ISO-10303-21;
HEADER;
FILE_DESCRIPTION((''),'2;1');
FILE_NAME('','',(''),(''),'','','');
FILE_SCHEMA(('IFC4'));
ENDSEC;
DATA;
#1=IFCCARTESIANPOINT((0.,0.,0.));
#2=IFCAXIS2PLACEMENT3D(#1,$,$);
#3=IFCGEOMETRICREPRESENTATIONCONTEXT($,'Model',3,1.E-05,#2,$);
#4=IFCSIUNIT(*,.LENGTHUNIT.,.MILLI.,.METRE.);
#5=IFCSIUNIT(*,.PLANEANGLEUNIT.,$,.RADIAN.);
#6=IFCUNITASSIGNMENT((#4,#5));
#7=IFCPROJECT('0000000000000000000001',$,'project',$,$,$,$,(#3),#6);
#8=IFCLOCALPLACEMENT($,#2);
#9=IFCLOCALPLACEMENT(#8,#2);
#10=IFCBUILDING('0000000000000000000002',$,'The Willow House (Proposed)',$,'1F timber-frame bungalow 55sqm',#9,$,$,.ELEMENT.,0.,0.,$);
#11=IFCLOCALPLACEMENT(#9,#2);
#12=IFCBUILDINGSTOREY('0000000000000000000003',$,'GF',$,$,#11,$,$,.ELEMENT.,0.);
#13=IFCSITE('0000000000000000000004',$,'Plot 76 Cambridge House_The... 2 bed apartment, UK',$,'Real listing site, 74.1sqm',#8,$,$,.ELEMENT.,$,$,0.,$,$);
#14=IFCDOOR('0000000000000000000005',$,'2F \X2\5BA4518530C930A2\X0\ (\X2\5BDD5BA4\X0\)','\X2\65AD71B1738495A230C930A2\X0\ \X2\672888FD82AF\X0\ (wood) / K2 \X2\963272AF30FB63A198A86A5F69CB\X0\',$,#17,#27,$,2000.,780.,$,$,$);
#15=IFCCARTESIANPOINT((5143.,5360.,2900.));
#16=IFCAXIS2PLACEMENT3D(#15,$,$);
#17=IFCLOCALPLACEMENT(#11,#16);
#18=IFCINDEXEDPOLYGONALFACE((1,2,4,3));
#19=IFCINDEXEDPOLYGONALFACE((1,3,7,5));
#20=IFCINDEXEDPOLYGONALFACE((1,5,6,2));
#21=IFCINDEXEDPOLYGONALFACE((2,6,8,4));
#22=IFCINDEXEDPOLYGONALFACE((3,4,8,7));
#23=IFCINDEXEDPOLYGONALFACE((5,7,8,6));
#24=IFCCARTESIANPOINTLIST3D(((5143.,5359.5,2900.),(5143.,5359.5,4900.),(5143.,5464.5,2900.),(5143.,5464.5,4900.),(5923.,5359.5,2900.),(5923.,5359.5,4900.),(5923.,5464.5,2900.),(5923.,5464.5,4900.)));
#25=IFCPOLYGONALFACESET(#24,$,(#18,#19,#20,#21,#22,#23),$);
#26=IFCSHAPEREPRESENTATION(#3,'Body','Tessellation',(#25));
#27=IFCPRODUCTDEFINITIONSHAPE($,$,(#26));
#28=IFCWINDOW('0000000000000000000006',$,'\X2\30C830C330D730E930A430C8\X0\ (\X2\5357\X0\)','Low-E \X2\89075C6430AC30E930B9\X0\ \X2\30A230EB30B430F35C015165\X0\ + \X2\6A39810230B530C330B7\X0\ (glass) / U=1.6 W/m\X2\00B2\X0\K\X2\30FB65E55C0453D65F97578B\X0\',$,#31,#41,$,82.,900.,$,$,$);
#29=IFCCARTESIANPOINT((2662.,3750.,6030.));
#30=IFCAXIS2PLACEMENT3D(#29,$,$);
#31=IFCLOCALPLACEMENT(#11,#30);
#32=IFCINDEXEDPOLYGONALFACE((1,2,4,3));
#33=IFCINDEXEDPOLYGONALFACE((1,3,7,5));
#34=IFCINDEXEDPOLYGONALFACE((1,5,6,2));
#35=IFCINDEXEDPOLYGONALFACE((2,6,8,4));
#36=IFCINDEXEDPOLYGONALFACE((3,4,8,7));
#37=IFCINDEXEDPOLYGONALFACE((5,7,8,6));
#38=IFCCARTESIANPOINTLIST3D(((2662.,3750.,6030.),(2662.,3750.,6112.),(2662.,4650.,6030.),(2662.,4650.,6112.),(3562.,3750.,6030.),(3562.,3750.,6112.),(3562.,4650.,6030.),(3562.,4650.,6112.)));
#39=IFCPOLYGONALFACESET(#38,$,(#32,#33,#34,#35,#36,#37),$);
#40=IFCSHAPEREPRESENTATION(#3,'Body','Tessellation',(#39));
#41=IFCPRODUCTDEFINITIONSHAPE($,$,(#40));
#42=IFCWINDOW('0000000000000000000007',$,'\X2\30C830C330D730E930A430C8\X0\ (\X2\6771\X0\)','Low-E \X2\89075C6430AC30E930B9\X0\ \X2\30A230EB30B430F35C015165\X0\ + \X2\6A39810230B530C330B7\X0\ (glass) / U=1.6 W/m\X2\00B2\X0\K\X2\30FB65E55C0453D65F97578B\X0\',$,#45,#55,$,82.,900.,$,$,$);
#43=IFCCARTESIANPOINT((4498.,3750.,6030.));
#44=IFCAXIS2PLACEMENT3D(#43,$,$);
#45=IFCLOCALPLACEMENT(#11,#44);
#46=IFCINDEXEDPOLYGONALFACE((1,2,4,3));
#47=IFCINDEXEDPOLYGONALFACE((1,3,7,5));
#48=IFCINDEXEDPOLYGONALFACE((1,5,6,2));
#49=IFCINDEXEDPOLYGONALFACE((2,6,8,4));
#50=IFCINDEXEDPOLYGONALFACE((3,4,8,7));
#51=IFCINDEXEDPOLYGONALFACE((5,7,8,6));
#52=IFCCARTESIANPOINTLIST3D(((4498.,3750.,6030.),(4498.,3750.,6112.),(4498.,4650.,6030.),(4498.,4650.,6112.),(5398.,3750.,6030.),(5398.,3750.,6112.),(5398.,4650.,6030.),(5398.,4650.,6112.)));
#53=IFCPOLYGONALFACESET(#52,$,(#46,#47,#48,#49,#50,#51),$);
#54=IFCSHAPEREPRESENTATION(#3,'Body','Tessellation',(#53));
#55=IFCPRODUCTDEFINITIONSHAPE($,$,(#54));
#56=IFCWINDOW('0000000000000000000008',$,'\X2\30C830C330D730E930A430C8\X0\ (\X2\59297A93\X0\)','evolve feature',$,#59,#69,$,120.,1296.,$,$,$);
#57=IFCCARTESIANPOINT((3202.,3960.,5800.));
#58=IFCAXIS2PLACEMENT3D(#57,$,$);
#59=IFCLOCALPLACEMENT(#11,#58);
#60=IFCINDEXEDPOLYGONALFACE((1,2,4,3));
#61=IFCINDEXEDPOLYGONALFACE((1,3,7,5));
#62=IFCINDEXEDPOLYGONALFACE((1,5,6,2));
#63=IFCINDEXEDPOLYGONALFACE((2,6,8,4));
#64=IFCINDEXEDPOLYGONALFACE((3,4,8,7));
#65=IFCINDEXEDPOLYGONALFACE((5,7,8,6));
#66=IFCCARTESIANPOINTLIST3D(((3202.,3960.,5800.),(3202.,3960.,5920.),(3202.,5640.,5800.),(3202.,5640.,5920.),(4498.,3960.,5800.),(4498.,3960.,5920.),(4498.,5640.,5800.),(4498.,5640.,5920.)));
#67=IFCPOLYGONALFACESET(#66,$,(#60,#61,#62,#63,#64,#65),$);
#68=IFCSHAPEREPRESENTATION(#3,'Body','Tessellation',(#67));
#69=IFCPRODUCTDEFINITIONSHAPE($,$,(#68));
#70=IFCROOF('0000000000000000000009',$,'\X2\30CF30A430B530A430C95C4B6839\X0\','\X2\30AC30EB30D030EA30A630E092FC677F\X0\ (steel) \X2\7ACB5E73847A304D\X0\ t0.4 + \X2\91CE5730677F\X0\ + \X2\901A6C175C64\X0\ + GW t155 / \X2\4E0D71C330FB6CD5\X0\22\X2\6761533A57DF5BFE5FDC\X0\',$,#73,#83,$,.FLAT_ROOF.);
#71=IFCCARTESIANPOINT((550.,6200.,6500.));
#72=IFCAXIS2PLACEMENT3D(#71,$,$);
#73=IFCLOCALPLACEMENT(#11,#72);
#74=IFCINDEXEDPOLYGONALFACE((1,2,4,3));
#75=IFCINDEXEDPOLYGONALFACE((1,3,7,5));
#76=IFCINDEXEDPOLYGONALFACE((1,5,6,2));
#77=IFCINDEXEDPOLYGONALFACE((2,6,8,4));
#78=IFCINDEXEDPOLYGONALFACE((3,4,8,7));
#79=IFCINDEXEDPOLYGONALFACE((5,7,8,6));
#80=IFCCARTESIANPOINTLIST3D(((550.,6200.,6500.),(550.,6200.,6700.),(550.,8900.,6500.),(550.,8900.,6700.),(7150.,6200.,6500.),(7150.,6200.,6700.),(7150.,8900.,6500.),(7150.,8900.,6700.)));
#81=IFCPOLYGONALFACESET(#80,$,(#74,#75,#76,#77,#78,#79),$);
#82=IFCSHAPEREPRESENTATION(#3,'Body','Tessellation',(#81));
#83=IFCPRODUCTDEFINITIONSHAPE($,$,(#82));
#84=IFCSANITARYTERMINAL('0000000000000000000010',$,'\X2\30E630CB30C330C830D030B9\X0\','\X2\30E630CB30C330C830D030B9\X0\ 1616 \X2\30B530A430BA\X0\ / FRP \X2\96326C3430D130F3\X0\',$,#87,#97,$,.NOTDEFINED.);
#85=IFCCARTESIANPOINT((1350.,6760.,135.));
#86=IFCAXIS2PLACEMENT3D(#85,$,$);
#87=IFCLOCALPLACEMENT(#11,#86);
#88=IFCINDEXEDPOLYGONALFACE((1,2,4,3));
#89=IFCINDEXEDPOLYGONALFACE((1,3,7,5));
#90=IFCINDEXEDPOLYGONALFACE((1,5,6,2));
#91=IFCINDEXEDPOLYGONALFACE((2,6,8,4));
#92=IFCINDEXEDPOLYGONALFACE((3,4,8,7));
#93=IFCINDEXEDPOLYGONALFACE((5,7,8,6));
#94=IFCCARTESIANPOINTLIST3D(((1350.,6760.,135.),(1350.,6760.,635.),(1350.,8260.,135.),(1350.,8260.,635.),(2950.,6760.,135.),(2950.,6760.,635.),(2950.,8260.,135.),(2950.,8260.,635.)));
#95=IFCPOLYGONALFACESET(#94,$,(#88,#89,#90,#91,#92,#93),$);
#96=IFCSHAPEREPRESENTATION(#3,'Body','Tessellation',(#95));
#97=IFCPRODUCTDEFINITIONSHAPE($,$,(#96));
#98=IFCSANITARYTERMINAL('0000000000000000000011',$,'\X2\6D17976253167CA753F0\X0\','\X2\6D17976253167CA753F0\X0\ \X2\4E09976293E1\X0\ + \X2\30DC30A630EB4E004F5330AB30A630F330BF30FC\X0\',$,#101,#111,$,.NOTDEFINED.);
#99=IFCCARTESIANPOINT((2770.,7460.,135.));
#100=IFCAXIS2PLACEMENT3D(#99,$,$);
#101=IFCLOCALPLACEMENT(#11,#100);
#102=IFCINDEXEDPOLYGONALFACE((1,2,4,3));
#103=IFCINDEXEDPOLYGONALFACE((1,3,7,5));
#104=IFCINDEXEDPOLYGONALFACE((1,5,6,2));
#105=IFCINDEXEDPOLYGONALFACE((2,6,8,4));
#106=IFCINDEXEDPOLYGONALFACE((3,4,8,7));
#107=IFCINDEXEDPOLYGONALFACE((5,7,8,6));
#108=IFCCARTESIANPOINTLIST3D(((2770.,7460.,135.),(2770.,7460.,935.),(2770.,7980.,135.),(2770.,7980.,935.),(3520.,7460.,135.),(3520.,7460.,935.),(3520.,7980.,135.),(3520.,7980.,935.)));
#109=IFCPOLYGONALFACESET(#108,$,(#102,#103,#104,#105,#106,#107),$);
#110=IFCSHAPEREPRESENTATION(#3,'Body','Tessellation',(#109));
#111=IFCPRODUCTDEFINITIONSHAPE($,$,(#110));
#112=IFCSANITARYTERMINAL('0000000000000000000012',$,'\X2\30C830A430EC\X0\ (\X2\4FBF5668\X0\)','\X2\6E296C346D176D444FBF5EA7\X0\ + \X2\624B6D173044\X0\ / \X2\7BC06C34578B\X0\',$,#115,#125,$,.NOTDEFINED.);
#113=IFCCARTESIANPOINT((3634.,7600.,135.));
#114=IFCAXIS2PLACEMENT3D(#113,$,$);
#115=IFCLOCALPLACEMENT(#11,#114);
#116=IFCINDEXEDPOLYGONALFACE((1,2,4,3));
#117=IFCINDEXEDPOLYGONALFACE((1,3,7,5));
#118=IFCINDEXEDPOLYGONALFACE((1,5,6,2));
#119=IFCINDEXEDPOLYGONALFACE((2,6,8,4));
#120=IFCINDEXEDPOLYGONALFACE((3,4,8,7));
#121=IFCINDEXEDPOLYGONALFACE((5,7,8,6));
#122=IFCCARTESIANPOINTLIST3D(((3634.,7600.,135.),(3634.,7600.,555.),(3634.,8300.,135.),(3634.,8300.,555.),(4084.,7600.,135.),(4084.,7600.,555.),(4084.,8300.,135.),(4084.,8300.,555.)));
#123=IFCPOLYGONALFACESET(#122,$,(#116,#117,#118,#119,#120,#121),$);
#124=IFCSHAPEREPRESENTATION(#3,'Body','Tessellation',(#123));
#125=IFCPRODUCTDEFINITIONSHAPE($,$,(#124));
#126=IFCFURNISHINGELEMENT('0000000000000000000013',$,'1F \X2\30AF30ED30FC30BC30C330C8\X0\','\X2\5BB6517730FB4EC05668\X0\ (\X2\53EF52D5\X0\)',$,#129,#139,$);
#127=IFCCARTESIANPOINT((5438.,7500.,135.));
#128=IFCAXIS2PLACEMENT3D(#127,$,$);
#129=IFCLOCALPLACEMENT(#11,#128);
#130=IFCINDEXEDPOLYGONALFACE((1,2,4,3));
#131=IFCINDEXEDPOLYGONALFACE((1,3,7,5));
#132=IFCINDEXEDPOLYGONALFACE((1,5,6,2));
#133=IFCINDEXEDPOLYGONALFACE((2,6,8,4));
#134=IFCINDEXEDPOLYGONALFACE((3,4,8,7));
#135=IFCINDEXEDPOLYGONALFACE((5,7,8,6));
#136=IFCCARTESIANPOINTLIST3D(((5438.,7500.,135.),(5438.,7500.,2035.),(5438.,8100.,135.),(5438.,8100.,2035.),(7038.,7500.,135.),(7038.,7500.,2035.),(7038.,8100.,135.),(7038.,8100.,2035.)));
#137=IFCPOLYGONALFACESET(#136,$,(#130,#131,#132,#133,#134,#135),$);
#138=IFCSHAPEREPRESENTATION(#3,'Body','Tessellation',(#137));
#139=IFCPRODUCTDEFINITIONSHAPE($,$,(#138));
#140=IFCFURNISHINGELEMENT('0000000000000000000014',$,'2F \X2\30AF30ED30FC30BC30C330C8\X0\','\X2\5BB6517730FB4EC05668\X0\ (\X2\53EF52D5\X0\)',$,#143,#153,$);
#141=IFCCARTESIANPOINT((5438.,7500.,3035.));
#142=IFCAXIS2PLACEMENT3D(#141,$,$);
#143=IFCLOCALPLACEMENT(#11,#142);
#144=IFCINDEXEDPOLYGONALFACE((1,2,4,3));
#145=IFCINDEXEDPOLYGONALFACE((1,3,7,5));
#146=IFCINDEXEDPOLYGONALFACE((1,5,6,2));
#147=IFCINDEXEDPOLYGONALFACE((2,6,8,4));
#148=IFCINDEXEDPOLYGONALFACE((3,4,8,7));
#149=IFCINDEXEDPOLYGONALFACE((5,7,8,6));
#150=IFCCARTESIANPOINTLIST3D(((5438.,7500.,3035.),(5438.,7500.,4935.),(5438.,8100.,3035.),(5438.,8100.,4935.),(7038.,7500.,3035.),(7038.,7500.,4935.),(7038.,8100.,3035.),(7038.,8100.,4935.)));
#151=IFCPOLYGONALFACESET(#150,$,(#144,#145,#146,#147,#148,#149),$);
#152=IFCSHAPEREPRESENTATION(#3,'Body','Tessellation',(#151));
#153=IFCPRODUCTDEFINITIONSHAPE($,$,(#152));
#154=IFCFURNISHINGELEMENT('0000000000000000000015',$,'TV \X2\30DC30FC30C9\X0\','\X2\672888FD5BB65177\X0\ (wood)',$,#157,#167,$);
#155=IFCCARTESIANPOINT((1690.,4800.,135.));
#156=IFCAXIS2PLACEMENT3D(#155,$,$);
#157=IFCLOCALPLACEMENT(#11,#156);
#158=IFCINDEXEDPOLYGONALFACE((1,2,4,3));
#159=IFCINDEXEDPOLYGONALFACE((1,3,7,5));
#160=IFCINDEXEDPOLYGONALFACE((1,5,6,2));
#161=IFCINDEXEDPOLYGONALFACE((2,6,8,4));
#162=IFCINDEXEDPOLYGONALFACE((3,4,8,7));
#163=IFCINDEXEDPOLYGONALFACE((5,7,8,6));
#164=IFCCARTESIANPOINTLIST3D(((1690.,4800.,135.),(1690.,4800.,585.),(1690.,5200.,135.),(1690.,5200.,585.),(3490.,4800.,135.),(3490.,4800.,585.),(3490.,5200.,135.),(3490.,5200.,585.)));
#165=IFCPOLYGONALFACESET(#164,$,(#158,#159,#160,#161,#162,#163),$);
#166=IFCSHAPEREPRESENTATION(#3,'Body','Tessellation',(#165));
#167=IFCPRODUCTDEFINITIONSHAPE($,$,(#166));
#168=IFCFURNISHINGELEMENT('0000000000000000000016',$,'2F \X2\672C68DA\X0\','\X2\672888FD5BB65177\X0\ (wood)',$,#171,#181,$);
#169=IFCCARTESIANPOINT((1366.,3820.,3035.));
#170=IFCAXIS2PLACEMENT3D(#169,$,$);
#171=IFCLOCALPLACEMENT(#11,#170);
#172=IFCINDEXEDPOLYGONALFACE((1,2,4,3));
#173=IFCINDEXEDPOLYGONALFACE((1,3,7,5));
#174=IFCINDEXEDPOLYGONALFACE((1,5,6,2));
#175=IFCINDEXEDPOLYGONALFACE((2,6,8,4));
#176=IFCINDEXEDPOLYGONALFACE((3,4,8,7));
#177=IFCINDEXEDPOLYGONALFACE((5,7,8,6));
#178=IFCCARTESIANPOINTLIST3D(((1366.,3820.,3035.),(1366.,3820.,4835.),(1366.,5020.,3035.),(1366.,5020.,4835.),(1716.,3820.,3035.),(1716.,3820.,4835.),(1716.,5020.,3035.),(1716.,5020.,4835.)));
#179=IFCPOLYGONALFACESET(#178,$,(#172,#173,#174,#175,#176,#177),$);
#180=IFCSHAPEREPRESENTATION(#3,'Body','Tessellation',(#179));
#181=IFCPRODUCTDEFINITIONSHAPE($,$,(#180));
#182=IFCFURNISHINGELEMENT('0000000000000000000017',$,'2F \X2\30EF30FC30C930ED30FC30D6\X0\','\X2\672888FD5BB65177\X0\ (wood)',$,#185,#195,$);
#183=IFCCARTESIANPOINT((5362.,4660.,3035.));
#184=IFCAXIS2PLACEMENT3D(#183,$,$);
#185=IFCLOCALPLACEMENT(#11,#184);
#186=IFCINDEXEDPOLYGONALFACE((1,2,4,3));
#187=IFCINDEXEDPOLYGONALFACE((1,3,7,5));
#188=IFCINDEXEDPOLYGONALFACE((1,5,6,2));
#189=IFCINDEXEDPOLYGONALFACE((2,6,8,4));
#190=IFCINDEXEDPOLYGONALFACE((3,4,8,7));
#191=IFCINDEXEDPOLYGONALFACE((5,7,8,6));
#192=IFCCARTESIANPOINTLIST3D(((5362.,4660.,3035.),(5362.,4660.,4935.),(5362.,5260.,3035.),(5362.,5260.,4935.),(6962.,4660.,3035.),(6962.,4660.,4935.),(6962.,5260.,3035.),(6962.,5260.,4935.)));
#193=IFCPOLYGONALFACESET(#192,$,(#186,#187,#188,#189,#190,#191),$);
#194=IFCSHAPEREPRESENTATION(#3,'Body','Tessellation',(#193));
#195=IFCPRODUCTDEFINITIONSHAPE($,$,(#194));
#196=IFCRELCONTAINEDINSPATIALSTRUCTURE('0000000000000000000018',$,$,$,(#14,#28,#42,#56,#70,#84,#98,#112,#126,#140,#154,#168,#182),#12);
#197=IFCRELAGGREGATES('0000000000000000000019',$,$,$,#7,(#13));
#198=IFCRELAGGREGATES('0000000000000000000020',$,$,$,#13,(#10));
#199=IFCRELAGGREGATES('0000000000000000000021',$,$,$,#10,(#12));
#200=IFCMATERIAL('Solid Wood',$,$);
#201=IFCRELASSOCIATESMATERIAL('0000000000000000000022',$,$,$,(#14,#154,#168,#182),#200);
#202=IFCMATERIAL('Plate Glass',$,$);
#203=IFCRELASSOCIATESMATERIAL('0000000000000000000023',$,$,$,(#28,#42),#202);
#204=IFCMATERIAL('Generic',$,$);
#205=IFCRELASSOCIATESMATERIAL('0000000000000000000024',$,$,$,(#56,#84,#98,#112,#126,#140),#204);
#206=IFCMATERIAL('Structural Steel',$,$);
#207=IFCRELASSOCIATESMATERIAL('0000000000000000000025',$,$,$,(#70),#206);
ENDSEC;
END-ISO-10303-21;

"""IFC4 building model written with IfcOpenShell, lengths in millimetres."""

from ifc_helpers import new_model, si_unit, frame, frame_2d, origin, place, context, project, spatial, rectangle, extrude, material, element, save


model = new_model("IFC4")

# Units and contexts
model_context = context("Model", 3, precision=1e-05, world=origin())
ifc_project = project(units=[si_unit("LENGTHUNIT", "METRE", prefix="MILLI"), si_unit("PLANEANGLEUNIT", "RADIAN")], contexts=[model_context])

# Site, building, storey
site_placement = place(None, origin())
site = spatial("IfcSite", under=ifc_project, at=site_placement, Name="Plot 76 Cambridge House_The... 2 bed apartment, UK", ObjectType="Real listing site, 74.1sqm", CompositionType="ELEMENT", RefElevation=0.0)
building_placement = place(site_placement, origin())
building = spatial("IfcBuilding", under=site, at=building_placement, Name="The Willow House (Proposed)", ObjectType="1F timber-frame bungalow 55sqm", CompositionType="ELEMENT", ElevationOfRefHeight=0.0, ElevationOfTerrain=0.0)
storey_placement = place(building_placement, origin())
storey = spatial("IfcBuildingStorey", under=building, at=storey_placement, Name="GF", CompositionType="ELEMENT", Elevation=0.0)

# Shared definitions
ifc_material_1 = material(Name="Solid Wood")
ifc_material_2 = material(Name="Plate Glass")

# Door
door_1_placement = place(storey_placement, frame((5143.0, 5360.0, 2900.0)))
element("IfcDoor", 1, at=door_1_placement, inside=storey, material=ifc_material_1, Name="2F 室内ドア (寝室)", Description="断熱玄関ドア 木製芯 (wood) / K2 防犯・採風機構", OverallHeight=2000.0, OverallWidth=780.0, context=model_context, shape_type="SweptSolid", body=[
    extrude(rectangle(XDim=780.0, YDim=105.0, at=frame_2d((390.0, 52.0))), frame((5143.0, 5360.0, 2900.0)), (0.0, 0.0, 1.0), 2000.0),
])

# Windows
window_1_placement = place(storey_placement, frame((2662.0, 3750.0, 6030.0)))
element("IfcWindow", 2, at=window_1_placement, inside=storey, material=ifc_material_2, Name="トップライト (南)", Description="Low-E 複層ガラス アルゴン封入 + 樹脂サッシ (glass) / U=1.6 W/m²K・日射取得型", OverallHeight=82.0, OverallWidth=900.0, context=model_context, shape_type="SweptSolid", body=[
    extrude(rectangle(XDim=900.0, YDim=900.0, at=frame_2d((450.0, 450.0))), frame((2662.0, 3750.0, 6030.0)), (0.0, 0.0, 1.0), 82.0),
])
window_2_placement = place(storey_placement, frame((4498.0, 3750.0, 6030.0)))
element("IfcWindow", 3, at=window_2_placement, inside=storey, material=ifc_material_2, Name="トップライト (東)", Description="Low-E 複層ガラス アルゴン封入 + 樹脂サッシ (glass) / U=1.6 W/m²K・日射取得型", OverallHeight=82.0, OverallWidth=900.0, context=model_context, shape_type="SweptSolid", body=[
    extrude(rectangle(XDim=900.0, YDim=900.0, at=frame_2d((450.0, 450.0))), frame((4498.0, 3750.0, 6030.0)), (0.0, 0.0, 1.0), 82.0),
])
ifc_material_3 = material(Name="Generic")
window_3_placement = place(storey_placement, frame((3202.0, 3960.0, 5800.0)))
element("IfcWindow", 4, at=window_3_placement, inside=storey, material=ifc_material_3, Name="トップライト (天窓)", Description="evolve feature", OverallHeight=120.0, OverallWidth=1296.0, context=model_context, shape_type="SweptSolid", body=[
    extrude(rectangle(XDim=1296.0, YDim=1680.0, at=frame_2d((648.0, 840.0))), frame((3202.0, 3960.0, 5800.0)), (0.0, 0.0, 1.0), 120.0),
])

# Roof
ifc_material_4 = material(Name="Structural Steel")
roof_placement = place(storey_placement, frame((550.0, 6200.0, 6500.0)))
element("IfcRoof", 5, at=roof_placement, inside=storey, material=ifc_material_4, Name="ハイサイド屋根", Description="ガルバリウム鋼板 (steel) 立平葺き t0.4 + 野地板 + 通気層 + GW t155 / 不燃・法22条区域対応", PredefinedType="FLAT_ROOF", context=model_context, shape_type="SweptSolid", body=[
    extrude(rectangle(XDim=6600.0, YDim=2700.0, at=frame_2d((3300.0, 1350.0))), frame((550.0, 6200.0, 6500.0)), (0.0, 0.0, 1.0), 200.0),
])

# Sanitary terminals
sanitary_terminal_1_placement = place(storey_placement, frame((1350.0, 6760.0, 135.0)))
element("IfcSanitaryTerminal", 6, at=sanitary_terminal_1_placement, inside=storey, material=ifc_material_3, Name="ユニットバス", Description="ユニットバス 1616 サイズ / FRP 防水パン", PredefinedType="NOTDEFINED", context=model_context, shape_type="SweptSolid", body=[
    extrude(rectangle(XDim=1600.0, YDim=1500.0, at=frame_2d((800.0, 750.0))), frame((1350.0, 6760.0, 135.0)), (0.0, 0.0, 1.0), 500.0),
])
sanitary_terminal_2_placement = place(storey_placement, frame((2770.0, 7460.0, 135.0)))
element("IfcSanitaryTerminal", 7, at=sanitary_terminal_2_placement, inside=storey, material=ifc_material_3, Name="洗面化粧台", Description="洗面化粧台 三面鏡 + ボウル一体カウンター", PredefinedType="NOTDEFINED", context=model_context, shape_type="SweptSolid", body=[
    extrude(rectangle(XDim=750.0, YDim=520.0, at=frame_2d((375.0, 260.0))), frame((2770.0, 7460.0, 135.0)), (0.0, 0.0, 1.0), 800.0),
])
sanitary_terminal_3_placement = place(storey_placement, frame((3634.0, 7600.0, 135.0)))
element("IfcSanitaryTerminal", 8, at=sanitary_terminal_3_placement, inside=storey, material=ifc_material_3, Name="トイレ (便器)", Description="温水洗浄便座 + 手洗い / 節水型", PredefinedType="NOTDEFINED", context=model_context, shape_type="SweptSolid", body=[
    extrude(rectangle(XDim=450.0, YDim=700.0, at=frame_2d((225.0, 350.0))), frame((3634.0, 7600.0, 135.0)), (0.0, 0.0, 1.0), 420.0),
])

# Furnishing elements
furnishing_1_placement = place(storey_placement, frame((5438.0, 7500.0, 135.0)))
element("IfcFurnishingElement", 9, at=furnishing_1_placement, inside=storey, material=ifc_material_3, Name="1F クローゼット", Description="家具・什器 (可動)", context=model_context, shape_type="SweptSolid", body=[
    extrude(rectangle(XDim=1600.0, YDim=600.0, at=frame_2d((800.0, 300.0))), frame((5438.0, 7500.0, 135.0)), (0.0, 0.0, 1.0), 1900.0),
])
furnishing_2_placement = place(storey_placement, frame((5438.0, 7500.0, 3035.0)))
element("IfcFurnishingElement", 10, at=furnishing_2_placement, inside=storey, material=ifc_material_3, Name="2F クローゼット", Description="家具・什器 (可動)", context=model_context, shape_type="SweptSolid", body=[
    extrude(rectangle(XDim=1600.0, YDim=600.0, at=frame_2d((800.0, 300.0))), frame((5438.0, 7500.0, 3035.0)), (0.0, 0.0, 1.0), 1900.0),
])
furnishing_3_placement = place(storey_placement, frame((1690.0, 4800.0, 135.0)))
element("IfcFurnishingElement", 11, at=furnishing_3_placement, inside=storey, material=ifc_material_1, Name="TV ボード", Description="木製家具 (wood)", context=model_context, shape_type="SweptSolid", body=[
    extrude(rectangle(XDim=1800.0, YDim=400.0, at=frame_2d((900.0, 200.0))), frame((1690.0, 4800.0, 135.0)), (0.0, 0.0, 1.0), 450.0),
])
furnishing_4_placement = place(storey_placement, frame((1366.0, 3820.0, 3035.0)))
element("IfcFurnishingElement", 12, at=furnishing_4_placement, inside=storey, material=ifc_material_1, Name="2F 本棚", Description="木製家具 (wood)", context=model_context, shape_type="SweptSolid", body=[
    extrude(rectangle(XDim=350.0, YDim=1200.0, at=frame_2d((175.0, 600.0))), frame((1366.0, 3820.0, 3035.0)), (0.0, 0.0, 1.0), 1800.0),
])
furnishing_5_placement = place(storey_placement, frame((5362.0, 4660.0, 3035.0)))
element("IfcFurnishingElement", 13, at=furnishing_5_placement, inside=storey, material=ifc_material_1, Name="2F ワードローブ", Description="木製家具 (wood)", context=model_context, shape_type="SweptSolid", body=[
    extrude(rectangle(XDim=1600.0, YDim=600.0, at=frame_2d((800.0, 300.0))), frame((5362.0, 4660.0, 3035.0)), (0.0, 0.0, 1.0), 1900.0),
])

save(model, "model.ifc")
